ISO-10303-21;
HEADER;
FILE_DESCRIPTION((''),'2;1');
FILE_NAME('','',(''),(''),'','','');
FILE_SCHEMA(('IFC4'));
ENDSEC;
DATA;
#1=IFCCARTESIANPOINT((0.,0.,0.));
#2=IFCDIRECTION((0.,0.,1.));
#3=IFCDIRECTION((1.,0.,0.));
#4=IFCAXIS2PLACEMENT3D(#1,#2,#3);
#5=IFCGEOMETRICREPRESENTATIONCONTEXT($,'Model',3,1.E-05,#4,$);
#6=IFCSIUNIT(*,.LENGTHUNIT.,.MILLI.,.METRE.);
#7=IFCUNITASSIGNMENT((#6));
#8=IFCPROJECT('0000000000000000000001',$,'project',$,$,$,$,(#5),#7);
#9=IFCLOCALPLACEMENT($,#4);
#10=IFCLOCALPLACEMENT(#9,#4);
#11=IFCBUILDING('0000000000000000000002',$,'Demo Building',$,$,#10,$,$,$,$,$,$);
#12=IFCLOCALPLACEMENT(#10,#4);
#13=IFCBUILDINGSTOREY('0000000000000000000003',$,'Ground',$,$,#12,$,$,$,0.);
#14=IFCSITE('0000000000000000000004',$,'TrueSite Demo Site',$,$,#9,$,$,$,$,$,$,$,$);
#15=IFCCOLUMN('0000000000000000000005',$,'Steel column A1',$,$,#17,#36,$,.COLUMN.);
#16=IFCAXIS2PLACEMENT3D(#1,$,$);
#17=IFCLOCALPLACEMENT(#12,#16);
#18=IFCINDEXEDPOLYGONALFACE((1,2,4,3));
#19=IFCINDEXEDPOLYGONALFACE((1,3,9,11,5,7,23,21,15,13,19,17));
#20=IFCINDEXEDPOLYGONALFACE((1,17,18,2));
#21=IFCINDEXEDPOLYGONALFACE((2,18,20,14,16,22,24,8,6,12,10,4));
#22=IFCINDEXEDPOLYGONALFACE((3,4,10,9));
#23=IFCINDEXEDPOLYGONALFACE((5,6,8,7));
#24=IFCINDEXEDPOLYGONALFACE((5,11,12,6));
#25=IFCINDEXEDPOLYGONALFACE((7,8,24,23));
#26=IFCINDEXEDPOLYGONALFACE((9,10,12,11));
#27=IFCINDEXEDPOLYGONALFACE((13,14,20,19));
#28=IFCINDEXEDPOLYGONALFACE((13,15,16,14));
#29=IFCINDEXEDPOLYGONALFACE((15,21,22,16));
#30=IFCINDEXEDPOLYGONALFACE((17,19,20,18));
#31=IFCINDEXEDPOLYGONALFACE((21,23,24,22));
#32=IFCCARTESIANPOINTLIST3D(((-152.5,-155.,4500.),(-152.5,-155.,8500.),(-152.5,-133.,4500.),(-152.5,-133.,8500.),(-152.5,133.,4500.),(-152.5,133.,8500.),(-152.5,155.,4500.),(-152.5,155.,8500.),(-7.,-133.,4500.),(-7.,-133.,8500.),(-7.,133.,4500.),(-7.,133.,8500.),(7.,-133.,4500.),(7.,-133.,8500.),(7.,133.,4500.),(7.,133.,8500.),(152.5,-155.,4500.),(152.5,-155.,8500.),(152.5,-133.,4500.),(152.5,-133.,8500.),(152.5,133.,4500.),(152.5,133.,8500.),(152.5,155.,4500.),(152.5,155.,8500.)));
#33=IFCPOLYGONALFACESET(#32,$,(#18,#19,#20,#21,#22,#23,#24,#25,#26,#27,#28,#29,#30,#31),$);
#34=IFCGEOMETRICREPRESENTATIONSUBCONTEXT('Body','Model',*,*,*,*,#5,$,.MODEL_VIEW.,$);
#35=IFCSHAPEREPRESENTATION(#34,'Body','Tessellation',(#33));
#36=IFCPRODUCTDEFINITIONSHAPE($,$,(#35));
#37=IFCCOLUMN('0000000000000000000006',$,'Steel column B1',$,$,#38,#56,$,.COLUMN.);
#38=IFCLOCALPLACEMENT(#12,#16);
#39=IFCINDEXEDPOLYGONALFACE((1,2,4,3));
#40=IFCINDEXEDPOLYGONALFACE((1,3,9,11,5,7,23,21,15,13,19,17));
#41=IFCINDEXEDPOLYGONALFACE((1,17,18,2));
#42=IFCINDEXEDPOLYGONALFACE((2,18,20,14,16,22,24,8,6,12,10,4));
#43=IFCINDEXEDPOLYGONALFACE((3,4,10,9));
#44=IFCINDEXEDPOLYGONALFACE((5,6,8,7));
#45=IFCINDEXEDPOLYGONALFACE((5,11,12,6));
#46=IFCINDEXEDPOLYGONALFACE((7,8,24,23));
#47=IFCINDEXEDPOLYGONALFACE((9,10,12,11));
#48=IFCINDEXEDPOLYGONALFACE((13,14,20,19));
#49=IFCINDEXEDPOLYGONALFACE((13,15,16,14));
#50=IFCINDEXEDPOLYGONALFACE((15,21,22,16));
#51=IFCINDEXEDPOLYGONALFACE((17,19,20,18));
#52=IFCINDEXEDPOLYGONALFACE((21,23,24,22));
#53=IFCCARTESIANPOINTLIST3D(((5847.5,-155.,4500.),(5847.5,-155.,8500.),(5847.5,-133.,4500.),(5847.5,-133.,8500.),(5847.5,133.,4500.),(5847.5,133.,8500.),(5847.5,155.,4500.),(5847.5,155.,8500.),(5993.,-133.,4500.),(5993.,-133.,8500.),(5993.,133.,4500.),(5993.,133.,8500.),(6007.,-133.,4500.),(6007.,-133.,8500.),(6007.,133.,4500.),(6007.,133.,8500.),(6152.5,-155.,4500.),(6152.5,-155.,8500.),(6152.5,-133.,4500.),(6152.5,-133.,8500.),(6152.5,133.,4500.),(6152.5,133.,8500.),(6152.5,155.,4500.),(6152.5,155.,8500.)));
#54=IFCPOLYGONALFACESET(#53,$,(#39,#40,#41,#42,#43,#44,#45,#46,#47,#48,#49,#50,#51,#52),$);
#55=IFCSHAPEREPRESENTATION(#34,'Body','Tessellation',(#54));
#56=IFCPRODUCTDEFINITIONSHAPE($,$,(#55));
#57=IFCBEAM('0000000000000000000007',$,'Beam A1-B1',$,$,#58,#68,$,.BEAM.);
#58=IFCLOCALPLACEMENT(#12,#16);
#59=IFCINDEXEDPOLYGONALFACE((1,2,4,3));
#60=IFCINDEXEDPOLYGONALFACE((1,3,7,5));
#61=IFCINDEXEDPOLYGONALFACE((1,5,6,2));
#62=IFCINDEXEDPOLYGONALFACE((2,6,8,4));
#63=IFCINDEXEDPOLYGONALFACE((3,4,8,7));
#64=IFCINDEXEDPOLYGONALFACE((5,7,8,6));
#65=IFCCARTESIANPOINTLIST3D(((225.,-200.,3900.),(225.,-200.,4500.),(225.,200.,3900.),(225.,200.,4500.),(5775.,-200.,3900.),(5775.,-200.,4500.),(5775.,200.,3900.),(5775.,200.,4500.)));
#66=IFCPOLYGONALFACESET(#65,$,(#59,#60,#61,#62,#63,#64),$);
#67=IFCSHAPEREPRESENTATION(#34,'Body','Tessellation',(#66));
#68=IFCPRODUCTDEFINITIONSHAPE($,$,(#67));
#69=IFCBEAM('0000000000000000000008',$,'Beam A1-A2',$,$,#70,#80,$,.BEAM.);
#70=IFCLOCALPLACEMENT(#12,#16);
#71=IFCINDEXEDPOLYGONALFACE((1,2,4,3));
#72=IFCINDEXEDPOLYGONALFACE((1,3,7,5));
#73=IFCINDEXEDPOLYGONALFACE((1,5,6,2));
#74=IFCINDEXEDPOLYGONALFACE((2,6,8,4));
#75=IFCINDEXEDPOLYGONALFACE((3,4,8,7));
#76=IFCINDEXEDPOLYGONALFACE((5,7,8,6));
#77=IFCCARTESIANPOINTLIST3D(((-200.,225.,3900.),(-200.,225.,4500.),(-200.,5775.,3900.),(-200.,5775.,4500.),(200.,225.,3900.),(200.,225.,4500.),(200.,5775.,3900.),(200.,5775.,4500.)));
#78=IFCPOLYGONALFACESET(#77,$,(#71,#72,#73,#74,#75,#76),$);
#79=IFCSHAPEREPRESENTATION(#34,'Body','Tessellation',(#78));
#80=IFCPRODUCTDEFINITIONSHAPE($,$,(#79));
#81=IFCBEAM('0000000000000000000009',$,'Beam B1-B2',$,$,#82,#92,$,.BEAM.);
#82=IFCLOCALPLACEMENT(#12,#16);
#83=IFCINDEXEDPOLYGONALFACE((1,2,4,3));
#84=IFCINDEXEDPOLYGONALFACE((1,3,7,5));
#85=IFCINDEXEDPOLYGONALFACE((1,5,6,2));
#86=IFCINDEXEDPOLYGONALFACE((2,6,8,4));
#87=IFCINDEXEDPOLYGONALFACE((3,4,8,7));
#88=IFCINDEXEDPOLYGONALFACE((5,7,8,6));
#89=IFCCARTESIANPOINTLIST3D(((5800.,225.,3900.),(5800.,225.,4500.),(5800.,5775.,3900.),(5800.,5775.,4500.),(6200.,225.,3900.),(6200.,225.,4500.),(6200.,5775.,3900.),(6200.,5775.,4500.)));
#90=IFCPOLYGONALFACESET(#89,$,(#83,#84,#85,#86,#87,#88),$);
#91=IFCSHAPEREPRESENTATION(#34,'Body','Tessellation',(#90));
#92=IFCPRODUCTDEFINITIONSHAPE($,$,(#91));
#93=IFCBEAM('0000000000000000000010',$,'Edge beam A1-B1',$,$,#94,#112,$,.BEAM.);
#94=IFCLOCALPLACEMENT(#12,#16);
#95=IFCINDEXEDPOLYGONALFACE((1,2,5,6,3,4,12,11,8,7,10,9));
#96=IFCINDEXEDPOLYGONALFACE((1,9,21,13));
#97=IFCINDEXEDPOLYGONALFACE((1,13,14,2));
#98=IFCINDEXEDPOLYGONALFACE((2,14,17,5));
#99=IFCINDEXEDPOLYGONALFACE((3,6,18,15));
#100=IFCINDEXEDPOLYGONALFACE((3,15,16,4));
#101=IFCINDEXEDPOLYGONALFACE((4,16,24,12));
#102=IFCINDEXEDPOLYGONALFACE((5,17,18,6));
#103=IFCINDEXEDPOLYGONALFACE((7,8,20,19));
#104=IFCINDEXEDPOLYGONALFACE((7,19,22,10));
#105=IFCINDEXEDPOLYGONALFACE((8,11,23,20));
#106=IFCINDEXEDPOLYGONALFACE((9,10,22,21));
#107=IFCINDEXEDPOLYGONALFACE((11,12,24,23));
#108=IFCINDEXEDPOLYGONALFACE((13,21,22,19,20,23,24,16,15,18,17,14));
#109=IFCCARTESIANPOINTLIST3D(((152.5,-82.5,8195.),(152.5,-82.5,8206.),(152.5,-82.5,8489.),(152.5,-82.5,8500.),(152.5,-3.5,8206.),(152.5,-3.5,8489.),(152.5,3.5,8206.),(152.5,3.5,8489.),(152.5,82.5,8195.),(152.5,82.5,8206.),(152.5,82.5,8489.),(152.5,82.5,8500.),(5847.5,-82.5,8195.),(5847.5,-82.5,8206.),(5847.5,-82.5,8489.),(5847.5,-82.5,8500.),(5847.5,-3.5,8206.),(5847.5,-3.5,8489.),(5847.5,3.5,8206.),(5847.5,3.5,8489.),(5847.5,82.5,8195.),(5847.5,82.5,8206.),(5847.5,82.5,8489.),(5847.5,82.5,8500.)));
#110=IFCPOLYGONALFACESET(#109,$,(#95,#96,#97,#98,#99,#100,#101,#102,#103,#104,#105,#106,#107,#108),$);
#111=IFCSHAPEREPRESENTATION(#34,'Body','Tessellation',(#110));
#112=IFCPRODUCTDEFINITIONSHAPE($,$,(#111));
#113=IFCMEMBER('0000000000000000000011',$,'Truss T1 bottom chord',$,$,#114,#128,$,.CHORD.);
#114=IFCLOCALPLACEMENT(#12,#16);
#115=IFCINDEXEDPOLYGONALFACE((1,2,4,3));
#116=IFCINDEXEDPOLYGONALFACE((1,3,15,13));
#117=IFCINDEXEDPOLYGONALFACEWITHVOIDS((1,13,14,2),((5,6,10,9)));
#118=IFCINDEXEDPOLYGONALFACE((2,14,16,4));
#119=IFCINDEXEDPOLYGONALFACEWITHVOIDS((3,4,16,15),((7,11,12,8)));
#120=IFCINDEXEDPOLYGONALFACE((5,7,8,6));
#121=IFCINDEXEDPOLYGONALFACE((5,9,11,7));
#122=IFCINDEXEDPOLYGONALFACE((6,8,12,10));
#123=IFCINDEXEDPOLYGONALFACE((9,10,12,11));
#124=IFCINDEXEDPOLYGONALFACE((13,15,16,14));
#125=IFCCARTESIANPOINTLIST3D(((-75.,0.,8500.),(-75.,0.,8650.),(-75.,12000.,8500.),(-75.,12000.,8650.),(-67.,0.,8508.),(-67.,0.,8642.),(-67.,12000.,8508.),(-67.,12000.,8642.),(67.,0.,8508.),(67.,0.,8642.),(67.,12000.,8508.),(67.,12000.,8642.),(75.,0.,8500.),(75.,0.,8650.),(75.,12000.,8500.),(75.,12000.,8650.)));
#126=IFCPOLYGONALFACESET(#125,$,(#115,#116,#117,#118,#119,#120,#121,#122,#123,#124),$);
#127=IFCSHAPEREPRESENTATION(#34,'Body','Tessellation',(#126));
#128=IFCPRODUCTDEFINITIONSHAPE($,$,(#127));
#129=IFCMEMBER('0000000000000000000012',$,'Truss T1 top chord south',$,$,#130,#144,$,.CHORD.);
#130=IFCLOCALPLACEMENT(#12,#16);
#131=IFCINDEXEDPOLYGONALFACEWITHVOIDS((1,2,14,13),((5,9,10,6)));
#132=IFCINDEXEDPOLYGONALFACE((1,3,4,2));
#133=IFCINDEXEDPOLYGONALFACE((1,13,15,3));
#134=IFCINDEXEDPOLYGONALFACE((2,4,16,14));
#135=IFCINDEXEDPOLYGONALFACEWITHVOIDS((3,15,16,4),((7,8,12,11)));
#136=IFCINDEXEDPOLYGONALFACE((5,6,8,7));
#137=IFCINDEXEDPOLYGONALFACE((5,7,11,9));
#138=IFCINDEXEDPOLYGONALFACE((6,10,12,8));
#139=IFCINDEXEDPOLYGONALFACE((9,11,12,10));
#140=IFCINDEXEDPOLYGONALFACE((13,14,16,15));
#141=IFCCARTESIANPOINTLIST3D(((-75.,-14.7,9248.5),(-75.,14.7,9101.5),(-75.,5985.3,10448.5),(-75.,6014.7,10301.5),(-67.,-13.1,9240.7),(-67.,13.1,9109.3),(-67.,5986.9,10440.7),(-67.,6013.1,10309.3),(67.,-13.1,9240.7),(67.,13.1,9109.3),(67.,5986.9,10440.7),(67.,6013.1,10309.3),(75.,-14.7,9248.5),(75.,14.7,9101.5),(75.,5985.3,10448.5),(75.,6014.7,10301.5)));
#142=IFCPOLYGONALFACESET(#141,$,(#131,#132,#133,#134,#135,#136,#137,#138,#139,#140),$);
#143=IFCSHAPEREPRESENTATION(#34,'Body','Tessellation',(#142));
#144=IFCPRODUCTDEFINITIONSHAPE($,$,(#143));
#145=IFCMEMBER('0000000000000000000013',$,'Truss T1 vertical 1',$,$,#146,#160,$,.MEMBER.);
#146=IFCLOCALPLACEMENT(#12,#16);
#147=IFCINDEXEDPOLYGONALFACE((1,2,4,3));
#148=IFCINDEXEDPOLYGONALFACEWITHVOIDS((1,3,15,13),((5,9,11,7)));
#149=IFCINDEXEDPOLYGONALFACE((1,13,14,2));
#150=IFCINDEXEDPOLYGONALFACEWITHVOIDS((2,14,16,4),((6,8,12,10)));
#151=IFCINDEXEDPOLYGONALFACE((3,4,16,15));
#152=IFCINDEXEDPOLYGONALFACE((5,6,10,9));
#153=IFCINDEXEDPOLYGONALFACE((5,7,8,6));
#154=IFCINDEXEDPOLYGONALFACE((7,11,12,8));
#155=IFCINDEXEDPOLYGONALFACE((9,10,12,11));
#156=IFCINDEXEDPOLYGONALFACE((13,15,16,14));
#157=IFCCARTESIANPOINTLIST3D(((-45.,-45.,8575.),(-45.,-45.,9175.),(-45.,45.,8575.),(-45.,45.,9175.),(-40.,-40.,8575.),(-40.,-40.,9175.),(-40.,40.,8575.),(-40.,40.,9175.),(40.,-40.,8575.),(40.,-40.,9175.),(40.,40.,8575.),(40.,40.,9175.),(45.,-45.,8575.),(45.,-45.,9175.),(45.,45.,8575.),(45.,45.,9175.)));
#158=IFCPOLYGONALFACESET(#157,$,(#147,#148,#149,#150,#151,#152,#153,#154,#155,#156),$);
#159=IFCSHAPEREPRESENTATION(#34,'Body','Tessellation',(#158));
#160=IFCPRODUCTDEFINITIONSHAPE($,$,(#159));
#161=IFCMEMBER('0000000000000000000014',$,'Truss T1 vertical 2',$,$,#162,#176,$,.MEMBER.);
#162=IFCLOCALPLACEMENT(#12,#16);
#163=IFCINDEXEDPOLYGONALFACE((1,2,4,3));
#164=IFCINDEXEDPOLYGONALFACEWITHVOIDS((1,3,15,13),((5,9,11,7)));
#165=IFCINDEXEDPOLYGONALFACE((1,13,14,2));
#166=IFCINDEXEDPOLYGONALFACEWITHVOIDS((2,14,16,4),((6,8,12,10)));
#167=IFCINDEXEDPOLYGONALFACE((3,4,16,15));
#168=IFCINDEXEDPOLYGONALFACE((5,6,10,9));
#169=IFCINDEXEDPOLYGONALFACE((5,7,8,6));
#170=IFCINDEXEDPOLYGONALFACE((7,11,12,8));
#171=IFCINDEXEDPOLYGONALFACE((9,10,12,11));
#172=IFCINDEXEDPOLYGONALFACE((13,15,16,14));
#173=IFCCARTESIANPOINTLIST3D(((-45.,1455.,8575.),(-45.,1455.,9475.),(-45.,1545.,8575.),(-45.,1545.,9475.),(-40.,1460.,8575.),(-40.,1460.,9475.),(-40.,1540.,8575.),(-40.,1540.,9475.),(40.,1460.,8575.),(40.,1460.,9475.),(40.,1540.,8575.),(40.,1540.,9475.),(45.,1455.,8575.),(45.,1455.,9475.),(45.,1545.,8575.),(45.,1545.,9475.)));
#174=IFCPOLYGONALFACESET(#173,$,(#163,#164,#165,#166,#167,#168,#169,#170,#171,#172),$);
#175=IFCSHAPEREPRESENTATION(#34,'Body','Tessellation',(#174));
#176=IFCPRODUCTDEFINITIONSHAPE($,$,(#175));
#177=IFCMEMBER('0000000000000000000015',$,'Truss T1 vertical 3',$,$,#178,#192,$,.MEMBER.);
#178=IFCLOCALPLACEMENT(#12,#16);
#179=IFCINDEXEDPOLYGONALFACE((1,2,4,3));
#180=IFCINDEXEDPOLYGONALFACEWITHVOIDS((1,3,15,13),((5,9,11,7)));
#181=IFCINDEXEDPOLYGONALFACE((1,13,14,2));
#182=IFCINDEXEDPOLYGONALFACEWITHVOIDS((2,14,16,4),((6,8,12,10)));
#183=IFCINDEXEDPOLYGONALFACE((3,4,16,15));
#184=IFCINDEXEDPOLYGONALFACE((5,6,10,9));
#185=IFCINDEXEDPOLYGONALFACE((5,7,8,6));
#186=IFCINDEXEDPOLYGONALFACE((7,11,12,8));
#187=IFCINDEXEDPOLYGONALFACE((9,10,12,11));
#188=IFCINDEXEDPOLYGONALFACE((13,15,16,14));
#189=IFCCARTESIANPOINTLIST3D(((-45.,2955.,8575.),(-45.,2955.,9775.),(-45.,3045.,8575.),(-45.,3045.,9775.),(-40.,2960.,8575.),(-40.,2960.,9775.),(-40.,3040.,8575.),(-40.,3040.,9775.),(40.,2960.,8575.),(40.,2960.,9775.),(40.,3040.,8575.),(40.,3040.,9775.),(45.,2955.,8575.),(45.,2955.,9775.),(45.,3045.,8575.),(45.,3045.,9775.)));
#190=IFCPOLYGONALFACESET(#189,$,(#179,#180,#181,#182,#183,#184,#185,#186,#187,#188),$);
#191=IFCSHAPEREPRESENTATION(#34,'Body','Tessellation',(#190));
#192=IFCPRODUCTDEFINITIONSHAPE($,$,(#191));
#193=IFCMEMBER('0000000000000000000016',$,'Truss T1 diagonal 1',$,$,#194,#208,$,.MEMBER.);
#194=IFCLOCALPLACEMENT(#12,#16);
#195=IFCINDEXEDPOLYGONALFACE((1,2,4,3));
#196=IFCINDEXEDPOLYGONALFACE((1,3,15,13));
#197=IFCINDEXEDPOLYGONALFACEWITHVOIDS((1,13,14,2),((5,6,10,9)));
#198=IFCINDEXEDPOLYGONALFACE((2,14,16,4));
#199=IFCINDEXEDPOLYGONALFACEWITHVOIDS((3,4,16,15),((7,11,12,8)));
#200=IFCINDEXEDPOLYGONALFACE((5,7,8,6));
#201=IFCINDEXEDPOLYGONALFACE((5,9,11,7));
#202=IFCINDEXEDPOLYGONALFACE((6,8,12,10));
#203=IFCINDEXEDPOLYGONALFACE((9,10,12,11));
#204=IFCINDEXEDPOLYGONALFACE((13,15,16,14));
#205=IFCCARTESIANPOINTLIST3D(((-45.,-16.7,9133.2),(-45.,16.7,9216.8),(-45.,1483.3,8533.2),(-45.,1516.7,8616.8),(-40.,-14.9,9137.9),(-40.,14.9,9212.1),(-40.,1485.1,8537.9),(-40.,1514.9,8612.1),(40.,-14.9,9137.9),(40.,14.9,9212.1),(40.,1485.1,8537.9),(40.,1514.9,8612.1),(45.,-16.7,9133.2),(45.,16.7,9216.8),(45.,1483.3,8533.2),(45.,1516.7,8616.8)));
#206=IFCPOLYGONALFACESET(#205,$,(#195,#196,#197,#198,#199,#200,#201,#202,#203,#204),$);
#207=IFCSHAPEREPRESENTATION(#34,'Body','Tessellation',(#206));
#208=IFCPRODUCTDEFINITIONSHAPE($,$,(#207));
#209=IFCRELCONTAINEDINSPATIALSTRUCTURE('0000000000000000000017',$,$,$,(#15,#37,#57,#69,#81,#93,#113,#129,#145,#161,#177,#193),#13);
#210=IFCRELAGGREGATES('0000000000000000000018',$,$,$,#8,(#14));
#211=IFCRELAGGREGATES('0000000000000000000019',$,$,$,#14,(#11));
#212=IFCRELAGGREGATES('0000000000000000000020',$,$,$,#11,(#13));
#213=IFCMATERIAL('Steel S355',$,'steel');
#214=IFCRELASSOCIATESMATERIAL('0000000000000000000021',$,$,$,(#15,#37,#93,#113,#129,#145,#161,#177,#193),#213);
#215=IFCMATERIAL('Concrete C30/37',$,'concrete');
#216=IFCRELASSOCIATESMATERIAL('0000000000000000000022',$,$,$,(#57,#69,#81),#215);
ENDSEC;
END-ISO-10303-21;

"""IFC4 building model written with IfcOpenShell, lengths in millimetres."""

from ifc_helpers import new_model, si_unit, frame, origin_with_axes, place, context, subcontext, project, spatial, rectangle, hollow_rectangle, i_section, extrude, material, element, save


model = new_model("IFC4")

# Units and contexts
model_context = context("Model", 3, precision=1e-05, world=origin_with_axes())
body_context = subcontext(model_context, "Body", "Model", "MODEL_VIEW")
ifc_project = project(units=[si_unit("LENGTHUNIT", "METRE", prefix="MILLI")], contexts=[model_context])

# Site, building, storey
site_placement = place(None, origin_with_axes())
site = spatial("IfcSite", under=ifc_project, at=site_placement, Name="TrueSite Demo Site")
building_placement = place(site_placement, origin_with_axes())
building = spatial("IfcBuilding", under=site, at=building_placement, Name="Demo Building")
storey_placement = place(building_placement, origin_with_axes())
storey = spatial("IfcBuildingStorey", under=building, at=storey_placement, Name="Ground", Elevation=0.0)

# Columns
ifc_material_1 = material(Name="Steel S355", Category="steel")
for number, where, z_axis, x_axis, name in (
    (1, (0.0, 0.0, 4500.0), (0.0, 0.0, 1.0), (1.0, 0.0, 0.0), "Steel column A1"),
    (2, (6000.0, 0.0, 4500.0), (0.0, 0.0, 1.0), (1.0, 0.0, 0.0), "Steel column B1"),
):
    element("IfcColumn", number, at=place(storey_placement, frame(where, z_axis=z_axis, x_axis=x_axis)), inside=storey, material=ifc_material_1, Name=name, PredefinedType="COLUMN", context=body_context, shape_type="SweptSolid", body=[
        extrude(i_section(OverallWidth=305.0, OverallDepth=310.0, WebThickness=14.0, FlangeThickness=22.0), origin_with_axes(), (0.0, 0.0, 1.0), 4000.0),
    ])

# Beams
ifc_material_2 = material(Name="Concrete C30/37", Category="concrete")
for number, where, z_axis, x_axis, name in (
    (3, (225.0, 0.0, 4200.0), (1.0, 0.0, 0.0), (0.0, 1.0, 0.0), "Beam A1-B1"),
    (4, (0.0, 225.0, 4200.0), (0.0, 1.0, 0.0), (-1.0, 0.0, 0.0), "Beam A1-A2"),
    (5, (6000.0, 225.0, 4200.0), (0.0, 1.0, 0.0), (-1.0, 0.0, 0.0), "Beam B1-B2"),
):
    element("IfcBeam", number, at=place(storey_placement, frame(where, z_axis=z_axis, x_axis=x_axis)), inside=storey, material=ifc_material_2, Name=name, PredefinedType="BEAM", context=body_context, shape_type="SweptSolid", body=[
        extrude(rectangle(XDim=400.0, YDim=600.0), origin_with_axes(), (0.0, 0.0, 1.0), 5550.0),
    ])
beam_placement = place(storey_placement, frame((152.5, 0.0, 8347.5), z_axis=(1.0, 0.0, 0.0), x_axis=(0.0, 1.0, 0.0)))
element("IfcBeam", 6, at=beam_placement, inside=storey, material=ifc_material_1, Name="Edge beam A1-B1", PredefinedType="BEAM", context=body_context, shape_type="SweptSolid", body=[
    extrude(i_section(OverallWidth=165.0, OverallDepth=305.0, WebThickness=7.0, FlangeThickness=11.0), origin_with_axes(), (0.0, 0.0, 1.0), 5695.0),
])

# Members
member_1_placement = place(storey_placement, frame((0.0, 0.0, 8575.0), z_axis=(0.0, 1.0, 0.0), x_axis=(-1.0, 0.0, 0.0)))
element("IfcMember", 7, at=member_1_placement, inside=storey, material=ifc_material_1, Name="Truss T1 bottom chord", PredefinedType="CHORD", context=body_context, shape_type="SweptSolid", body=[
    extrude(hollow_rectangle(XDim=150.0, YDim=150.0, WallThickness=8.0), origin_with_axes(), (0.0, 0.0, 1.0), 12000.0),
])
member_2_placement = place(storey_placement, frame((0.0, 0.0, 9175.0), z_axis=(0.0, 0.980581, 0.196116), x_axis=(-1.0, 0.0, 0.0)))
element("IfcMember", 8, at=member_2_placement, inside=storey, material=ifc_material_1, Name="Truss T1 top chord south", PredefinedType="CHORD", context=body_context, shape_type="SweptSolid", body=[
    extrude(hollow_rectangle(XDim=150.0, YDim=150.0, WallThickness=8.0), origin_with_axes(), (0.0, 0.0, 1.0), 6118.8),
])
member_3_placement = place(storey_placement, frame((0.0, 0.0, 8575.0), z_axis=(0.0, 0.0, 1.0), x_axis=(1.0, 0.0, 0.0)))
element("IfcMember", 9, at=member_3_placement, inside=storey, material=ifc_material_1, Name="Truss T1 vertical 1", PredefinedType="MEMBER", context=body_context, shape_type="SweptSolid", body=[
    extrude(hollow_rectangle(XDim=90.0, YDim=90.0, WallThickness=5.0), origin_with_axes(), (0.0, 0.0, 1.0), 600.0),
])
member_4_placement = place(storey_placement, frame((0.0, 1500.0, 8575.0), z_axis=(0.0, 0.0, 1.0), x_axis=(1.0, 0.0, 0.0)))
element("IfcMember", 10, at=member_4_placement, inside=storey, material=ifc_material_1, Name="Truss T1 vertical 2", PredefinedType="MEMBER", context=body_context, shape_type="SweptSolid", body=[
    extrude(hollow_rectangle(XDim=90.0, YDim=90.0, WallThickness=5.0), origin_with_axes(), (0.0, 0.0, 1.0), 900.0),
])
member_5_placement = place(storey_placement, frame((0.0, 3000.0, 8575.0), z_axis=(0.0, 0.0, 1.0), x_axis=(1.0, 0.0, 0.0)))
element("IfcMember", 11, at=member_5_placement, inside=storey, material=ifc_material_1, Name="Truss T1 vertical 3", PredefinedType="MEMBER", context=body_context, shape_type="SweptSolid", body=[
    extrude(hollow_rectangle(XDim=90.0, YDim=90.0, WallThickness=5.0), origin_with_axes(), (0.0, 0.0, 1.0), 1200.0),
])
member_6_placement = place(storey_placement, frame((0.0, 0.0, 9175.0), z_axis=(0.0, 0.928477, -0.371391), x_axis=(-1.0, 0.0, 0.0)))
element("IfcMember", 12, at=member_6_placement, inside=storey, material=ifc_material_1, Name="Truss T1 diagonal 1", PredefinedType="MEMBER", context=body_context, shape_type="SweptSolid", body=[
    extrude(hollow_rectangle(XDim=90.0, YDim=90.0, WallThickness=5.0), origin_with_axes(), (0.0, 0.0, 1.0), 1615.5),
])

save(model, "model.ifc")
